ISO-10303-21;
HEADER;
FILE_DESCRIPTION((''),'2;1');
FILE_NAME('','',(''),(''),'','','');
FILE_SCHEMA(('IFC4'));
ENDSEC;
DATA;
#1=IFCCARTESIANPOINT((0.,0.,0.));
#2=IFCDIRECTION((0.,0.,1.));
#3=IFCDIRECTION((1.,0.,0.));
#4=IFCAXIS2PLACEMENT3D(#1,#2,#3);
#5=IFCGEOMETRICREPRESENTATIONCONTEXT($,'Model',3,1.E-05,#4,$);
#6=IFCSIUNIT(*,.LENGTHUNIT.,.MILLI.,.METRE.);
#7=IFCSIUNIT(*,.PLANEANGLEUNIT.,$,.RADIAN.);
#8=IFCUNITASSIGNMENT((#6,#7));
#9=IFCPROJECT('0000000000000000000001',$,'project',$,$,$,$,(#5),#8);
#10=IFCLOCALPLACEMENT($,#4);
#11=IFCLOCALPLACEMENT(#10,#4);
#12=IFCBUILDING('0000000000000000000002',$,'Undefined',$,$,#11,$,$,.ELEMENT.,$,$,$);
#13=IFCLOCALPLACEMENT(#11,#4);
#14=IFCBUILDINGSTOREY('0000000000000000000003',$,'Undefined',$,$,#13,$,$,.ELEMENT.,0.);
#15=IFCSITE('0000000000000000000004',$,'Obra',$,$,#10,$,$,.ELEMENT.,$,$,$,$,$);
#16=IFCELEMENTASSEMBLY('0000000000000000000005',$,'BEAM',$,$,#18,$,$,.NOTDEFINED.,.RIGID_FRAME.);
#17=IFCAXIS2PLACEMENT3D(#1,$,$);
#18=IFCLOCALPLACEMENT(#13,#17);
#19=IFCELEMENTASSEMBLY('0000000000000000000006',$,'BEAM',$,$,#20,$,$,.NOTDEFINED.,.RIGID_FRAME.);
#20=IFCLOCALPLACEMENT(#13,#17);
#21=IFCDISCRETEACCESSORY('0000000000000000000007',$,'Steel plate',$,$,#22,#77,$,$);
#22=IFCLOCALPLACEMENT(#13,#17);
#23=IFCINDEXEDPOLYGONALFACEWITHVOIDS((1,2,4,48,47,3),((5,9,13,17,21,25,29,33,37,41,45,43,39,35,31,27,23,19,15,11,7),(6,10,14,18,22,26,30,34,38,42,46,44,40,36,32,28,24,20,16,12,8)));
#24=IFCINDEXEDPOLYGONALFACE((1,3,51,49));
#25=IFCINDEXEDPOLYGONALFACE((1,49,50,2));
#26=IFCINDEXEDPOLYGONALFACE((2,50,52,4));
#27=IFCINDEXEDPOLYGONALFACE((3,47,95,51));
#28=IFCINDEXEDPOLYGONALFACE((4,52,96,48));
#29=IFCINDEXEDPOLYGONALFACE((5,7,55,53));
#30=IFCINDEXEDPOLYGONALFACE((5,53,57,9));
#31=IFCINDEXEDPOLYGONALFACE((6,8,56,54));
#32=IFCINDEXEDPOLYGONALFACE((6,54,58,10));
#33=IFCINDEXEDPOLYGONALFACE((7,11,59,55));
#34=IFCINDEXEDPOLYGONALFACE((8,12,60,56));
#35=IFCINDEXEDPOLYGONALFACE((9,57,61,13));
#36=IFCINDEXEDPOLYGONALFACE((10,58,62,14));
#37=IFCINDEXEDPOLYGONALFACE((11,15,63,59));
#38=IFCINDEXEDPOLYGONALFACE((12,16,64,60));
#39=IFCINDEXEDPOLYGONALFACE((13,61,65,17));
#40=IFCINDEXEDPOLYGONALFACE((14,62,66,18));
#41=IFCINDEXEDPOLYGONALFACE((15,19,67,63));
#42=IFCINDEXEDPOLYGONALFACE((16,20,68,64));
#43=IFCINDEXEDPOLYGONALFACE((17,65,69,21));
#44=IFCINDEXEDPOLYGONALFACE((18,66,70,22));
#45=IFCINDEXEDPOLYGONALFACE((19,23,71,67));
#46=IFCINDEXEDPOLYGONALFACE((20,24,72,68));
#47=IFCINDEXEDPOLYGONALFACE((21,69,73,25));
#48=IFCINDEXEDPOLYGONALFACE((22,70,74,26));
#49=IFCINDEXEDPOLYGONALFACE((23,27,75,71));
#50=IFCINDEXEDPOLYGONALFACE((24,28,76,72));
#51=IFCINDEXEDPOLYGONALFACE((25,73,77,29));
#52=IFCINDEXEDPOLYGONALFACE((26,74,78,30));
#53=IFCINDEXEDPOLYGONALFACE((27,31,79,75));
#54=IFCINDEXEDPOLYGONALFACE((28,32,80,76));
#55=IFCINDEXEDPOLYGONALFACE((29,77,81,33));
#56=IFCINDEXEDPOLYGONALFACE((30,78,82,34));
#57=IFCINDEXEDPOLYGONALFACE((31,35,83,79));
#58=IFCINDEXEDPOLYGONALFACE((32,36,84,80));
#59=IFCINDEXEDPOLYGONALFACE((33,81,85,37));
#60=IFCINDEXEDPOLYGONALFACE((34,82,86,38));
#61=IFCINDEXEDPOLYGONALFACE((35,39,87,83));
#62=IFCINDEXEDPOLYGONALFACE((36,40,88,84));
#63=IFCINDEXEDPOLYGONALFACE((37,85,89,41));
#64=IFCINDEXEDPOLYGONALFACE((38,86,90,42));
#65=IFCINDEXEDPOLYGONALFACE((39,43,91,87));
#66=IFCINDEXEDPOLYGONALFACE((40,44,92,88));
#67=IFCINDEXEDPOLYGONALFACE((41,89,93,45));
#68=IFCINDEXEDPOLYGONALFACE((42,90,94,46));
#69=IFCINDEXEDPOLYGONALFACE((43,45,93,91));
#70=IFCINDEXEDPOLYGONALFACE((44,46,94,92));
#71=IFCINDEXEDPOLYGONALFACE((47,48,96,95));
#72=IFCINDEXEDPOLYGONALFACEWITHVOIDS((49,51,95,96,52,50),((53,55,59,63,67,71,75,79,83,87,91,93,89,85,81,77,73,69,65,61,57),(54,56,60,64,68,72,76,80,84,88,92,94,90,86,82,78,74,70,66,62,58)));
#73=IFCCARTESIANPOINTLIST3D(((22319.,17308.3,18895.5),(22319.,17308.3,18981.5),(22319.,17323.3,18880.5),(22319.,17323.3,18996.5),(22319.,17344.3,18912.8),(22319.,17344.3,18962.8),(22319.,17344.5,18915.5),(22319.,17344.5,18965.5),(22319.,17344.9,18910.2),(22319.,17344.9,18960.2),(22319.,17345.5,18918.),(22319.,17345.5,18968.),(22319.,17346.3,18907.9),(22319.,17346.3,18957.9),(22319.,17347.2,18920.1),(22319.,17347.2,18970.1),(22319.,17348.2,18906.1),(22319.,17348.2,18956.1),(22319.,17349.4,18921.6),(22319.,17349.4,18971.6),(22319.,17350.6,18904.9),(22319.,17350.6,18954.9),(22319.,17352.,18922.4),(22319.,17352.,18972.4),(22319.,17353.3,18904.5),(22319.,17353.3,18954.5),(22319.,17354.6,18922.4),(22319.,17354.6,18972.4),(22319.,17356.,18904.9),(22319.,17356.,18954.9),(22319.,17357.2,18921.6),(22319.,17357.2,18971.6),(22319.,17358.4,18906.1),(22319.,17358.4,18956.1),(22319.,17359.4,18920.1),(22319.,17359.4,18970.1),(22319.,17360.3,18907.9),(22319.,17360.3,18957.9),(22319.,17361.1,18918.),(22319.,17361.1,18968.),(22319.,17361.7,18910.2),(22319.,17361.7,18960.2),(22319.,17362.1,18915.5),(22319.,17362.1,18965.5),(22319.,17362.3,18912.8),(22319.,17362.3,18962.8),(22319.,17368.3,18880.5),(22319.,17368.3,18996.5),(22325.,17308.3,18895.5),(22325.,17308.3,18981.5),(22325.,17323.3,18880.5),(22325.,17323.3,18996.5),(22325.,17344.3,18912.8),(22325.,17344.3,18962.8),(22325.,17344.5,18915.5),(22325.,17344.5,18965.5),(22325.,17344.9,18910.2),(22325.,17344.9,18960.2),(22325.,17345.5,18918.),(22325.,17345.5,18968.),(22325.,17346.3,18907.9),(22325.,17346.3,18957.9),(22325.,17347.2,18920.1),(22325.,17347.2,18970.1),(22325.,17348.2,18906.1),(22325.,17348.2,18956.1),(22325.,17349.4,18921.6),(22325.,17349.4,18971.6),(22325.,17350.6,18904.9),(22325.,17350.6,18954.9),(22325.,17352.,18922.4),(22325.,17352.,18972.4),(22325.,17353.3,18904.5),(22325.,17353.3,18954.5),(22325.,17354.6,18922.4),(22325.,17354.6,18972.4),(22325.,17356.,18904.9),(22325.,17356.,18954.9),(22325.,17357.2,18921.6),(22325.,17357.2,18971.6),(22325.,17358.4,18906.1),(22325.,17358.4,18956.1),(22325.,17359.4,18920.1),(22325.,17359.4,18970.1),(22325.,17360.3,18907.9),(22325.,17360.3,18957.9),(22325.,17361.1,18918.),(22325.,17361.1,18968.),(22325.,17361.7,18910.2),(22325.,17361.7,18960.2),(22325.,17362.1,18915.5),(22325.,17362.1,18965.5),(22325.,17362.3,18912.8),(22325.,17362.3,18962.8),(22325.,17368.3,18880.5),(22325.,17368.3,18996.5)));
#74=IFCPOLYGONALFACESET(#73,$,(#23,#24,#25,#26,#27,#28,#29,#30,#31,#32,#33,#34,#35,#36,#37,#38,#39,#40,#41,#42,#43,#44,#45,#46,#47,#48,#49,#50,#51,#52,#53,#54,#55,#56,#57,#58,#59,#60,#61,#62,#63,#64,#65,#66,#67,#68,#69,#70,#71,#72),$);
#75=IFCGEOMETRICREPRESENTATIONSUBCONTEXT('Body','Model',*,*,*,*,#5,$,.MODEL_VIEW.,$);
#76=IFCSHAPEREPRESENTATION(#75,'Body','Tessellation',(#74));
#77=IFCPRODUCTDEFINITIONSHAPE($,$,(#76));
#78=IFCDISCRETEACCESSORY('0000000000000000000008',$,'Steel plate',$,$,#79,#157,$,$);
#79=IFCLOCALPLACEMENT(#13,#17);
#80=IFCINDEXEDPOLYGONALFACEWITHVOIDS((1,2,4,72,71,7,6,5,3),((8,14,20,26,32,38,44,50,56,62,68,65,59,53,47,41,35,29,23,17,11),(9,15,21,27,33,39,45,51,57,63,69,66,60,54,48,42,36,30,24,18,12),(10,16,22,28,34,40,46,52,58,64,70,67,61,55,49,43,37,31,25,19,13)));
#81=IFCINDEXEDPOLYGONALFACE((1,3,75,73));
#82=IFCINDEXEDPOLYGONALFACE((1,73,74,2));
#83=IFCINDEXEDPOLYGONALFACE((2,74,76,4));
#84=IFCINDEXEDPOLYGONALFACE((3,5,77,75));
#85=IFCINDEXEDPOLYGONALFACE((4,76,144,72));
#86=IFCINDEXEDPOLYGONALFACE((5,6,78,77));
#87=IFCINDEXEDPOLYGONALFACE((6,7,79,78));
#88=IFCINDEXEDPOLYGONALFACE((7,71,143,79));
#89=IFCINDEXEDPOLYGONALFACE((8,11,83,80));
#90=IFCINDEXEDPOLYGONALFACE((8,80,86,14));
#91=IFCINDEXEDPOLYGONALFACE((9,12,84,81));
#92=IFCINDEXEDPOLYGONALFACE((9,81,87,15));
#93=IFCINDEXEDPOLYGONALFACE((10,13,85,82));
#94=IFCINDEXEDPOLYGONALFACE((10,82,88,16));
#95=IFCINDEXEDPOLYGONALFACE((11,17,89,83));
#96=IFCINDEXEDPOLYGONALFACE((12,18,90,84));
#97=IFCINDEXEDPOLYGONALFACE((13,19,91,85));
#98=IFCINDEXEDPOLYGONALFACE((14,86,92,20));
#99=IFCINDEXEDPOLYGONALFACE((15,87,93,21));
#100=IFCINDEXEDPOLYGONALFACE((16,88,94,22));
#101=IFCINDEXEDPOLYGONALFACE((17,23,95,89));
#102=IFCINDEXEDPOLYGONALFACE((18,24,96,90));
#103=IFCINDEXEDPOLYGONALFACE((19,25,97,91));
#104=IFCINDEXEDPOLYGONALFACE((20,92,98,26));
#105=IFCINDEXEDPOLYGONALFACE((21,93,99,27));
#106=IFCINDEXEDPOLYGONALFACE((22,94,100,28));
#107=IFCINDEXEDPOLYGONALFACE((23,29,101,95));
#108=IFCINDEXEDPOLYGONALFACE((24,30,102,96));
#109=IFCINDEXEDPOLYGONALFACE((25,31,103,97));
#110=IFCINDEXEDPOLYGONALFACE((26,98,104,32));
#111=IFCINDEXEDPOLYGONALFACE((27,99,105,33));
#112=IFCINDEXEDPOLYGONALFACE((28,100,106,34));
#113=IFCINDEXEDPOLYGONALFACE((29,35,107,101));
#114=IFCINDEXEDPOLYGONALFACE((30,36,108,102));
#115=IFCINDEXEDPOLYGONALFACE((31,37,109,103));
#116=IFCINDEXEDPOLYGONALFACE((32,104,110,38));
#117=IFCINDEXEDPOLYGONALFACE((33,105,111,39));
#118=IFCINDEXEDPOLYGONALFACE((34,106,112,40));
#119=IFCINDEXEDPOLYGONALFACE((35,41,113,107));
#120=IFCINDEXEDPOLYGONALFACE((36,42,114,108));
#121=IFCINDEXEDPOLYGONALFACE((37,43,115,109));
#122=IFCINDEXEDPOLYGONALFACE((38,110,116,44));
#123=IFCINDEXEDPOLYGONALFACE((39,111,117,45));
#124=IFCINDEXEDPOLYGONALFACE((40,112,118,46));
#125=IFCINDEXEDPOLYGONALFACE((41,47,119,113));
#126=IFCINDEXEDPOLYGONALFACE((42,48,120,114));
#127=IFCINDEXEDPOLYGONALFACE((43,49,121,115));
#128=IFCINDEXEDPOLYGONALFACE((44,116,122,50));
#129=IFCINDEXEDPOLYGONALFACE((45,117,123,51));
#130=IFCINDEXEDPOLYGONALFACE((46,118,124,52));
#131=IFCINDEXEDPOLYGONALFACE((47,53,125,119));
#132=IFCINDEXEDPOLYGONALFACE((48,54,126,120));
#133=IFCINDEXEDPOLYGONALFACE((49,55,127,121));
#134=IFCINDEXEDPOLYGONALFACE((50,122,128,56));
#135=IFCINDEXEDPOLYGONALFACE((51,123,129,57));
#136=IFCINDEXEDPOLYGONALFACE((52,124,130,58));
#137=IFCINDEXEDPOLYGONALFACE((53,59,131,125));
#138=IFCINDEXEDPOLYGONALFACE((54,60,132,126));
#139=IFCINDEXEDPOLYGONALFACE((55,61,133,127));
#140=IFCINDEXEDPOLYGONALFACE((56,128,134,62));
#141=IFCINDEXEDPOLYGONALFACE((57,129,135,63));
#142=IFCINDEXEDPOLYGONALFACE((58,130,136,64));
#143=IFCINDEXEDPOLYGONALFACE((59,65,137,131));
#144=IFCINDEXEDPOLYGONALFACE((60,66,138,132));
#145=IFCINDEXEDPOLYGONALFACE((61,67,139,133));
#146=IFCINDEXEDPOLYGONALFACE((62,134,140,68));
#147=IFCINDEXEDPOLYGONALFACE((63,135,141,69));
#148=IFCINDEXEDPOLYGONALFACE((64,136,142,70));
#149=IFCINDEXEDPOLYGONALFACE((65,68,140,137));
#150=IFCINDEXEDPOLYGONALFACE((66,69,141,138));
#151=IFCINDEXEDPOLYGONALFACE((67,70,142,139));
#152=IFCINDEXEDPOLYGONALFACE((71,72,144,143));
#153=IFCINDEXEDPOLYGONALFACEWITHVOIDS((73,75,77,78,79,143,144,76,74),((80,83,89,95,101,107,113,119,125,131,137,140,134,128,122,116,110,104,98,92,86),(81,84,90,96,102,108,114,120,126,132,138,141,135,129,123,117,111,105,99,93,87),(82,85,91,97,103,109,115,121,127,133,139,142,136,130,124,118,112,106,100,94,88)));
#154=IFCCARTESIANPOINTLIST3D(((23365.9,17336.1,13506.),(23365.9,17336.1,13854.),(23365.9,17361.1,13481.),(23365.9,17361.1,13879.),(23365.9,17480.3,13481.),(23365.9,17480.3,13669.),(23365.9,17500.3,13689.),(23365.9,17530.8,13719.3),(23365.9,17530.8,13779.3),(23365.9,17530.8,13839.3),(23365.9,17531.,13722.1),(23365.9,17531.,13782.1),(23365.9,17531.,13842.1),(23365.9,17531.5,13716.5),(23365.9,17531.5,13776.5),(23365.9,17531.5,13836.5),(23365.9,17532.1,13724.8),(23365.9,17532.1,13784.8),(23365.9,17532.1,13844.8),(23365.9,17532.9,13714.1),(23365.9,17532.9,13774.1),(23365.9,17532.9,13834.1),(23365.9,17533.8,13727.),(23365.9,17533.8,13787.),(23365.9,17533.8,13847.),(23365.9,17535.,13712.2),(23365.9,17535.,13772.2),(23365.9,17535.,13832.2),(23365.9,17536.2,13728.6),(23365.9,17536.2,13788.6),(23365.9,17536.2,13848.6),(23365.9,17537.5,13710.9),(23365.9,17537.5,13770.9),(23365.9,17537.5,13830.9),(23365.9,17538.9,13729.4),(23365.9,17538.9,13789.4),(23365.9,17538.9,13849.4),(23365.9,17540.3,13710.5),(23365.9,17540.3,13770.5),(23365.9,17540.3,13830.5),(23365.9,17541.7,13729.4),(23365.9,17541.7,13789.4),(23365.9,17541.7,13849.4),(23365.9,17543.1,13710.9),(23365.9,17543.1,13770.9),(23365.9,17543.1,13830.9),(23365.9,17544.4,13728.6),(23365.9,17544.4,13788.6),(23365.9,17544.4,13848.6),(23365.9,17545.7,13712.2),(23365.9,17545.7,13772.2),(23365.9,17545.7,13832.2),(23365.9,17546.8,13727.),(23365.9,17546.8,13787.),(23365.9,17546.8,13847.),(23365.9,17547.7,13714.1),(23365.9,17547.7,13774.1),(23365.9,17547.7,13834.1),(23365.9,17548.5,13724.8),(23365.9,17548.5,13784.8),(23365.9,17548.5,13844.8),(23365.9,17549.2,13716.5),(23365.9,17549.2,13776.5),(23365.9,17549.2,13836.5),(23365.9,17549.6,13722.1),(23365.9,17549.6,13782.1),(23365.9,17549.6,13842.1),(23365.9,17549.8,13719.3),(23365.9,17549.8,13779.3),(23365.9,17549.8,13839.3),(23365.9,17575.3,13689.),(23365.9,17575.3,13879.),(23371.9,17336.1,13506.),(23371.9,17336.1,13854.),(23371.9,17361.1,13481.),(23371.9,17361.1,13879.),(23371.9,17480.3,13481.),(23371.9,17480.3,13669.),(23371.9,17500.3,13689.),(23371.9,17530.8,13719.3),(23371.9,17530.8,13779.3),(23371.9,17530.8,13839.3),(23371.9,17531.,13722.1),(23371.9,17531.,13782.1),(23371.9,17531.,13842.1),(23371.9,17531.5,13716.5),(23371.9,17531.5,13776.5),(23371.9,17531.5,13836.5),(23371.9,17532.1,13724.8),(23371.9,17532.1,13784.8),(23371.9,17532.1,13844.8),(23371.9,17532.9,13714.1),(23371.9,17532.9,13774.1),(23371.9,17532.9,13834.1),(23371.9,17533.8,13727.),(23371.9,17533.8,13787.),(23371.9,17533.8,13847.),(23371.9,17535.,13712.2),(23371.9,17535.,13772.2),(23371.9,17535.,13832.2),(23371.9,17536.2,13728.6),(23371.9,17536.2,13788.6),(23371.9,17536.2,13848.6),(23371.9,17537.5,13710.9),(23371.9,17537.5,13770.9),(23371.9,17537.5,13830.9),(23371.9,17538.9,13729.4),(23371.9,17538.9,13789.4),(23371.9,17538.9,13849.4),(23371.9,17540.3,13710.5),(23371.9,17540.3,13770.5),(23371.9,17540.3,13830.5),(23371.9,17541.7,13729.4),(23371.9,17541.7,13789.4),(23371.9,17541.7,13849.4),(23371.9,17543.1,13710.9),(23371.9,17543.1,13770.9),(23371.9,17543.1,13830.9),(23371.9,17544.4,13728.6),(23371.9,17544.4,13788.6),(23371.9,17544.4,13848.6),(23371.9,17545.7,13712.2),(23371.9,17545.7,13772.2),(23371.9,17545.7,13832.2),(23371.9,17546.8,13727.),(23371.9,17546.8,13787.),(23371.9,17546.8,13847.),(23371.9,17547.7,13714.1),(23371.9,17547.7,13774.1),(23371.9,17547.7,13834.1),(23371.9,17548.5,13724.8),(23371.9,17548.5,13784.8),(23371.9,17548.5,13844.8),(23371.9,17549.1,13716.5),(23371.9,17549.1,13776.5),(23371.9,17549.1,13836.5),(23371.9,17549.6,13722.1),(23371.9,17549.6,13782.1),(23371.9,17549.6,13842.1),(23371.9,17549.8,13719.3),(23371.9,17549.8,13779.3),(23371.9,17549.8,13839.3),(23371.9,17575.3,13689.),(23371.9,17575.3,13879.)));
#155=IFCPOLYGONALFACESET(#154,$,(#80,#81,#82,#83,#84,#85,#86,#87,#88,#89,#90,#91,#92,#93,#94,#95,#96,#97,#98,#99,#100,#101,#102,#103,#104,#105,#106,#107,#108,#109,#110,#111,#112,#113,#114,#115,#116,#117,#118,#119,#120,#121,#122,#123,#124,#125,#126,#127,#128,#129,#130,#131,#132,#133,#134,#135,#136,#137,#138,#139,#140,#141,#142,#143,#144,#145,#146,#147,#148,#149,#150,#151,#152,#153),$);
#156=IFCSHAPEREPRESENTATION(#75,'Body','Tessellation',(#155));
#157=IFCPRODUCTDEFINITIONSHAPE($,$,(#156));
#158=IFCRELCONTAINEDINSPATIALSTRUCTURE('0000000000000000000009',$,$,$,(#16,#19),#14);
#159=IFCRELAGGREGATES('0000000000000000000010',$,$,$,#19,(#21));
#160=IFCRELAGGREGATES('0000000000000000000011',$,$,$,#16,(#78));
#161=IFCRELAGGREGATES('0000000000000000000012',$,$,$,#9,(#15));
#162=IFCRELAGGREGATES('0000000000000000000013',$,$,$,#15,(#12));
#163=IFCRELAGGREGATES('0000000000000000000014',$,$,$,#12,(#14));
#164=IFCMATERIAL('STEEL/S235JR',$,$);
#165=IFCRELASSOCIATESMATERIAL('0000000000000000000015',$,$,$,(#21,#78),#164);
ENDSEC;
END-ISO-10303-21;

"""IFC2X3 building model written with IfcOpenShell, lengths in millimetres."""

from ifc_helpers import new_model, si_unit, frame, origin_with_axes, origin_2d_with_axis, place, context, subcontext, project, spatial, polyline, circle, outline, extrude, source, transform, mapped, material, element, aggregate, save


model = new_model("IFC2X3")

# Units and contexts
model_context = context("Model", 3, precision=1e-05, world=origin_with_axes())
body_context = subcontext(model_context, "Body", "Model", "MODEL_VIEW")
ifc_project = project(units=[si_unit("LENGTHUNIT", "METRE", prefix="MILLI"), si_unit("PLANEANGLEUNIT", "RADIAN")], contexts=[model_context])

# Site, building, storey
site_placement = place(None, origin_with_axes())
site = spatial("IfcSite", under=ifc_project, at=site_placement, Name="Obra", CompositionType="ELEMENT")
building_placement = place(site_placement, origin_with_axes())
building = spatial("IfcBuilding", under=site, at=building_placement, Name="Undefined", CompositionType="ELEMENT")
storey_placement = place(building_placement, origin_with_axes())
storey = spatial("IfcBuildingStorey", under=building, at=storey_placement, Name="Undefined", CompositionType="ELEMENT", Elevation=0.0)

# Shared definitions
ifc_material_1 = material(Name="STEEL/S235JR")

# Element assembly
shared_shape_1 = source(origin_with_axes(), body_context, "Body", "SweptSolid", [
    extrude(circle(Radius=9.0, at=origin_2d_with_axis()), frame((0.0, -8.8, 0.0), z_axis=(0.0, 1.0, 0.0), x_axis=(1.0, 0.0, 0.0)), (0.0, 0.0, 1.0), 6.2),
])
assembly_1_placement = place(storey_placement, origin_with_axes())
assembly_1 = element("IfcElementAssembly", 1, at=assembly_1_placement, inside=storey, Name="BEAM", AssemblyPlace="NOTDEFINED", PredefinedType="RIGID_FRAME")

# Element assembly, discrete accessory, opening
assembly_2_placement = place(storey_placement, origin_with_axes())
assembly_2 = element("IfcElementAssembly", 2, at=assembly_2_placement, inside=storey, Name="BEAM", AssemblyPlace="NOTDEFINED", PredefinedType="RIGID_FRAME")
discrete_accessory_1_placement = place(assembly_2_placement, frame((22322.0, 17368.3, 18880.5), z_axis=(-1.0, 0.0, 0.0), x_axis=(0.0, -1.0, 0.0)))
discrete_accessory_1 = element("IfcDiscreteAccessory", 3, at=discrete_accessory_1_placement, material=ifc_material_1, Name="Steel plate", context=body_context, shape_type="SweptSolid", body=[
    extrude(outline(polyline([(0.0, 0.0), (45.0, 0.0), (60.0, 15.0), (60.0, 101.0), (45.0, 116.0), (0.0, 116.0), (0.0, 0.0)])), frame((0.0, 0.0, -3.0), z_axis=(0.0, 0.0, 1.0), x_axis=(1.0, 0.0, 0.0)), (0.0, 0.0, 1.0), 6.0),
])
opening_1_placement = place(assembly_2_placement, frame((22316.3, 17318.3, 19005.0), z_axis=(0.0, 1.0, 0.0), x_axis=(0.0, 0.0, -1.0)))
element("IfcOpeningElement", 4, at=opening_1_placement, cuts=discrete_accessory_1, ObjectType="Opening", context=body_context, shape_type="MappedRepresentation", body=[
    mapped(shared_shape_1, transform((41.5, 0.0, 35.0))),
    mapped(shared_shape_1, transform((91.5, 0.0, 35.0))),
])
aggregate(assembly_2, [discrete_accessory_1])

# Discrete accessory, opening
discrete_accessory_2_placement = place(assembly_1_placement, frame((23368.9, 17336.1, 13506.0), z_axis=(1.0, -0.000129, 0.0), x_axis=(0.000091, 0.707107, -0.707107)))
discrete_accessory_2 = element("IfcDiscreteAccessory", 5, at=discrete_accessory_2_placement, material=ifc_material_1, Name="Steel plate", context=body_context, shape_type="SweptSolid", body=[
    extrude(outline(polyline([(0.0, 0.0), (35.4, 0.0), (119.7, 84.3), (-13.3, 217.3), (-13.3, 245.5), (39.8, 298.6), (-94.6, 432.9), (-246.1, 281.4), (-246.1, 246.1), (0.0, 0.0)])), frame((0.0, 0.0, -3.0), z_axis=(0.0, 0.0, 1.0), x_axis=(1.0, 0.0, 0.0)), (0.0, 0.0, 1.0), 6.0),
])
shared_shape_2 = source(origin_with_axes(), body_context, "Body", "SweptSolid", [
    extrude(circle(Radius=9.5, at=origin_2d_with_axis()), frame((0.0, 3.0, 0.0), z_axis=(0.0, 1.0, 0.0), x_axis=(1.0, 0.0, 0.0)), (0.0, 0.0, 1.0), 6.2),
])
opening_2_placement = place(assembly_1_placement, frame((23375.0, 17490.3, 13879.0), z_axis=(0.000129, 1.0, 0.0), x_axis=(0.0, 0.0, -1.0)))
element("IfcOpeningElement", 6, at=opening_2_placement, cuts=discrete_accessory_2, ObjectType="Opening", context=body_context, shape_type="MappedRepresentation", body=[
    mapped(shared_shape_2, transform((159.0, 0.0, 50.0))),
    mapped(shared_shape_2, transform((99.0, 0.0, 50.0))),
    mapped(shared_shape_2, transform((39.0, 0.0, 50.0))),
])
aggregate(assembly_1, [discrete_accessory_2])

save(model, "model.ifc")
